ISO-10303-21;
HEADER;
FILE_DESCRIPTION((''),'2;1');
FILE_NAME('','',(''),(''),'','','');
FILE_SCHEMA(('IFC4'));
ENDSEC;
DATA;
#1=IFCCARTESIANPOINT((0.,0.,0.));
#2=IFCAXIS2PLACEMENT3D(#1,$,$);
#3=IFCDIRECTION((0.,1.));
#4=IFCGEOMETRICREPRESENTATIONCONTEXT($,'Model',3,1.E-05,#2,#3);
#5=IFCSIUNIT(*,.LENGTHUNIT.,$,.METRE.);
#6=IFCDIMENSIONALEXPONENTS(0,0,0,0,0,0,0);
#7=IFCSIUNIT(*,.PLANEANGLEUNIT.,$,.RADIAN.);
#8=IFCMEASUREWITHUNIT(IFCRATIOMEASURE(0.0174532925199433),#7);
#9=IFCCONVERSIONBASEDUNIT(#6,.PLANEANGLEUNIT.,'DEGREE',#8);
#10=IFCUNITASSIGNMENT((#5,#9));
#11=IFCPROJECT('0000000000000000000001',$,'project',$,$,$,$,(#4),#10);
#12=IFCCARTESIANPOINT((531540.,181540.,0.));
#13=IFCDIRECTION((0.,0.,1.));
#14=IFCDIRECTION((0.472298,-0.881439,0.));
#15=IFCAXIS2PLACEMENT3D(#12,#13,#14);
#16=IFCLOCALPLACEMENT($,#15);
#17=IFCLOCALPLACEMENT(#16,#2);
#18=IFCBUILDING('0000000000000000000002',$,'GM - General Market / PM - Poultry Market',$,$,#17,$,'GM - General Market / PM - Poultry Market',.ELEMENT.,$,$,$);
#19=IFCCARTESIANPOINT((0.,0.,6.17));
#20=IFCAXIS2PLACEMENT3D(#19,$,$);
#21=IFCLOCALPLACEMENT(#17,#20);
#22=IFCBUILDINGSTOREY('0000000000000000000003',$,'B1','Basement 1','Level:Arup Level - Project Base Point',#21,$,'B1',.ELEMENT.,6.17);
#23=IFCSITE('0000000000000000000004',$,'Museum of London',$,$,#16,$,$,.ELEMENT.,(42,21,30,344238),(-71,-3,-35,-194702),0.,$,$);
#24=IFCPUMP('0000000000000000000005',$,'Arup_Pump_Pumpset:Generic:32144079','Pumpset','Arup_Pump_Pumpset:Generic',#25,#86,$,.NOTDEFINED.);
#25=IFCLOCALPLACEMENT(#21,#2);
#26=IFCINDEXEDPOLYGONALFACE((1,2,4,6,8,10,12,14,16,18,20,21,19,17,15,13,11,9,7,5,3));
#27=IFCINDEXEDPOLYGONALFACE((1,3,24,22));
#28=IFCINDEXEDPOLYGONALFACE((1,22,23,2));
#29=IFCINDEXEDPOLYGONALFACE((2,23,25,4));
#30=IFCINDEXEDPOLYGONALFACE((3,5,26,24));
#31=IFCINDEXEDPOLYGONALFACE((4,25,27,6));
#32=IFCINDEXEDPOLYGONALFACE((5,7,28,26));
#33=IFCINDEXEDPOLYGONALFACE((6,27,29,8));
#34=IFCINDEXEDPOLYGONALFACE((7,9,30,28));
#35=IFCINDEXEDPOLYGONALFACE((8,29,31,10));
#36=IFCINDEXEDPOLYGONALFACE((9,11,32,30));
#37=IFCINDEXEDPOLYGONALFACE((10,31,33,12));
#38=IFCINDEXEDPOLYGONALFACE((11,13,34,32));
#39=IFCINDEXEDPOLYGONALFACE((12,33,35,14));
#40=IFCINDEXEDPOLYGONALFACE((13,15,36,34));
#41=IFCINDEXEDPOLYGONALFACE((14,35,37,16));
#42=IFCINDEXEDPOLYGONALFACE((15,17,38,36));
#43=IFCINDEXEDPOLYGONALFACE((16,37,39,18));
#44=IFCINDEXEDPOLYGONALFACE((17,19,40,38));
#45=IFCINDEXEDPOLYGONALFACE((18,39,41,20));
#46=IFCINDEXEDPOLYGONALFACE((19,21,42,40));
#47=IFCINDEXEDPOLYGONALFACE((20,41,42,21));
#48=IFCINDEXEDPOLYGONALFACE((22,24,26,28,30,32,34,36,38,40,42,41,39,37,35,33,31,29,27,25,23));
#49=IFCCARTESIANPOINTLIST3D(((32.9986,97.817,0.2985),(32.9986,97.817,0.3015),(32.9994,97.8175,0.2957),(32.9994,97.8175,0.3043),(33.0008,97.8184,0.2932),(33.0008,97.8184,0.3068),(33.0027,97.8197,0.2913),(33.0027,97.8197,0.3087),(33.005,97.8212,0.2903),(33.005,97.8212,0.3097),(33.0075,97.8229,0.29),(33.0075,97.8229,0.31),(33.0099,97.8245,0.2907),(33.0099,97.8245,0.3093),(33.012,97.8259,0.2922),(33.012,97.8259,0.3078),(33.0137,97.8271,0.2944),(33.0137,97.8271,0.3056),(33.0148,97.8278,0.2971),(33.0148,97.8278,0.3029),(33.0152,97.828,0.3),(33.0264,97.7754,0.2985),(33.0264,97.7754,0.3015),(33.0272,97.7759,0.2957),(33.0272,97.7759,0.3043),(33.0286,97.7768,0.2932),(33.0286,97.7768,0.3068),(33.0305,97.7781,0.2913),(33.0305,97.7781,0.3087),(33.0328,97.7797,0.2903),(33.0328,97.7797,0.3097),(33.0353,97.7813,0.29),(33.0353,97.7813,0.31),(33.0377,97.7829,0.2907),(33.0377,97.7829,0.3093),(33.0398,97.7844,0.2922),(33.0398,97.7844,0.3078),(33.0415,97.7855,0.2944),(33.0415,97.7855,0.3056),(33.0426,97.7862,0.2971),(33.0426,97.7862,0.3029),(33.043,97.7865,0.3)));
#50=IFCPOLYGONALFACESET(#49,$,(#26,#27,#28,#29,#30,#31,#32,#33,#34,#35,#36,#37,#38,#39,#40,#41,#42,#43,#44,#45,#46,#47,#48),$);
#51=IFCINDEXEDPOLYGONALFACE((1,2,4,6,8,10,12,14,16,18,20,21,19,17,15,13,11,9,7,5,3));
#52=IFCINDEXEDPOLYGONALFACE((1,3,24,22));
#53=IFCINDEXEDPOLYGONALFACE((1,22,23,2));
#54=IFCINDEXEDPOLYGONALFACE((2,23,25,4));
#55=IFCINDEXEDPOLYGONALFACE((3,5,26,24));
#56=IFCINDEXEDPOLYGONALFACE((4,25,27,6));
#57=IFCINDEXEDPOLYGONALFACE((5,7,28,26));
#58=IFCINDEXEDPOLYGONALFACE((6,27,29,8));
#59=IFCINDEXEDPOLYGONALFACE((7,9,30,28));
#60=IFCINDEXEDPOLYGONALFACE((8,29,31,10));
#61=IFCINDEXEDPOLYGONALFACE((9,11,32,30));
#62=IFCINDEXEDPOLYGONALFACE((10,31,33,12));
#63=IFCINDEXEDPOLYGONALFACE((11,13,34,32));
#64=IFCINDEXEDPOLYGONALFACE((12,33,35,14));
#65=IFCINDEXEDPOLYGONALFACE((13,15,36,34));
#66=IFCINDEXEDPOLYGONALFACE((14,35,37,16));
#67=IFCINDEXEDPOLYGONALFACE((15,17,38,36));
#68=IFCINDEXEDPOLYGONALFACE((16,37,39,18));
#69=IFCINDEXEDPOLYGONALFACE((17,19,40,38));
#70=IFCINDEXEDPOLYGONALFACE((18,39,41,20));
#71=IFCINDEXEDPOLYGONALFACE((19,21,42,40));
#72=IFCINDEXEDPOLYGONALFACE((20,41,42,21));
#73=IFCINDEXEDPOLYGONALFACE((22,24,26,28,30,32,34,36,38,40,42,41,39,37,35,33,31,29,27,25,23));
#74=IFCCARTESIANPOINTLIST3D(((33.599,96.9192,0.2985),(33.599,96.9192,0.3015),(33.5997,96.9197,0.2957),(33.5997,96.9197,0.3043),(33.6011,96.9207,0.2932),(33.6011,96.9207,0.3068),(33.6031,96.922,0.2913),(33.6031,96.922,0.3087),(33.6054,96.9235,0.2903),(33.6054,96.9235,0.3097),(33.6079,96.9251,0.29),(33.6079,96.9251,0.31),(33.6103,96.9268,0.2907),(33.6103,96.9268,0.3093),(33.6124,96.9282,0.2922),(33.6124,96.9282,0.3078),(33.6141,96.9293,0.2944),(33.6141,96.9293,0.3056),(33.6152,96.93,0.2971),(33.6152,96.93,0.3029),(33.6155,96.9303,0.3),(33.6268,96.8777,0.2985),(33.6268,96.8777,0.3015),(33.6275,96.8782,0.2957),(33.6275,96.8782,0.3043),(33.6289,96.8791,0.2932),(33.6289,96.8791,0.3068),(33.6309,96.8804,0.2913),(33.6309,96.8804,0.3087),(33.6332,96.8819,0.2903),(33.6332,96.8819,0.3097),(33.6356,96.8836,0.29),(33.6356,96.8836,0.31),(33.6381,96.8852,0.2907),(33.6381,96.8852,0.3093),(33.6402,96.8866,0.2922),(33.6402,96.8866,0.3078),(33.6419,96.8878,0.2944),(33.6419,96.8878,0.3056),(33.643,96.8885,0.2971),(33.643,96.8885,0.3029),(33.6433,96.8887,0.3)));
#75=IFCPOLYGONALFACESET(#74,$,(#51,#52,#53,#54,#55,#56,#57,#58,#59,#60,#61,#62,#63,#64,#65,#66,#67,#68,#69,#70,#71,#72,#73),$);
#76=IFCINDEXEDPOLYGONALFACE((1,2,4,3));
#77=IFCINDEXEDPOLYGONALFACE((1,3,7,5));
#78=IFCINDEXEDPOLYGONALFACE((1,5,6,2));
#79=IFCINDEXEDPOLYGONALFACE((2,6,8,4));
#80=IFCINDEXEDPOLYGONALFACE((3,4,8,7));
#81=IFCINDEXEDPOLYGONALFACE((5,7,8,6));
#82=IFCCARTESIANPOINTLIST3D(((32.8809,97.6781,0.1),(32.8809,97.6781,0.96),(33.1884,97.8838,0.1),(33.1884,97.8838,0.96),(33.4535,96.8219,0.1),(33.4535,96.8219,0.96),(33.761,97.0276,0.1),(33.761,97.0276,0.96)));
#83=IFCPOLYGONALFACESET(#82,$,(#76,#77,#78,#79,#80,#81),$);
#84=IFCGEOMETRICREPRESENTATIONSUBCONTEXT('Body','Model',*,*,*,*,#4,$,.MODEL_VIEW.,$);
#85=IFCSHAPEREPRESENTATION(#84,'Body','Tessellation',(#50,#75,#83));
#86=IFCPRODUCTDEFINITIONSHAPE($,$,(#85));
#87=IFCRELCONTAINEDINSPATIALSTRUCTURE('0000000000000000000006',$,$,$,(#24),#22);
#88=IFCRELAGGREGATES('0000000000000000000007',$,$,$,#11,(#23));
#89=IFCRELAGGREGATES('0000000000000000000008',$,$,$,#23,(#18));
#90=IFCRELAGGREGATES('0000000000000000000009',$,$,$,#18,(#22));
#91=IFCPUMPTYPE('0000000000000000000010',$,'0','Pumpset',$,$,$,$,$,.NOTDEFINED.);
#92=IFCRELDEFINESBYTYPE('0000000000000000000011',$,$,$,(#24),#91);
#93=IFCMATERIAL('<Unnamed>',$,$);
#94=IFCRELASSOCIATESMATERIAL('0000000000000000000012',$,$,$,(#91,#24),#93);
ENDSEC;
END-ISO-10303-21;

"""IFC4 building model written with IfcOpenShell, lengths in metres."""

from ifc_helpers import new_model, entity, si_unit, converted_unit, direction, frame, frame_2d, origin, origin_2d_with_axis, place, context, subcontext, project, spatial, rectangle, circle, extrude, source, transform, mapped, material, type_object, type_shapes, element, save


model = new_model("IFC4")

# Units and contexts
model_context = context("Model", 3, precision=1e-05, world=origin(), true_north=direction((0.0, 1.0)))
body_context = subcontext(model_context, "Body", "Model", "MODEL_VIEW")
ifc_project = project(units=[si_unit("LENGTHUNIT", "METRE"), converted_unit("PLANEANGLEUNIT", "DEGREE", entity("IfcRatioMeasure", 0.0174532925199433), si_unit("PLANEANGLEUNIT", "RADIAN"), dimensions=[0, 0, 0, 0, 0, 0, 0])], contexts=[model_context])

# Site, building, storey
site_placement = place(None, frame((531540.0, 181540.0, 0.0), z_axis=(0.0, 0.0, 1.0), x_axis=(0.472298, -0.881439, 0.0)))
site = spatial("IfcSite", under=ifc_project, at=site_placement, Name="Museum of London", CompositionType="ELEMENT", RefLatitude=(42, 21, 30, 344238), RefLongitude=(-71, -3, -35, -194702), RefElevation=0.0)
building_placement = place(site_placement, origin())
building = spatial("IfcBuilding", under=site, at=building_placement, Name="GM - General Market / PM - Poultry Market", LongName="GM - General Market / PM - Poultry Market", CompositionType="ELEMENT")
storey_placement = place(building_placement, frame((0.0, 0.0, 6.17)))
storey = spatial("IfcBuildingStorey", under=building, at=storey_placement, Name="B1", Description="Basement 1", ObjectType="Level:Arup Level - Project Base Point", LongName="B1", CompositionType="ELEMENT", Elevation=6.17)

# Shared definitions
ifc_material_1 = material(Name="<Unnamed>")

# Pump
pump_type = type_object("IfcPumpType", Name="0", Description="Pumpset", PredefinedType="NOTDEFINED", material=ifc_material_1)
shared_shape_1 = source(origin(), body_context, "Body", "SweptSolid", [
    extrude(circle(Radius=0.01, at=frame_2d((0.0, 0.0), x_axis=(1.0, 0.0))), frame((-0.015, 0.515, 0.2), z_axis=(0.0, 1.0, 0.0), x_axis=(1.0, 0.0, 0.0)), (0.0, 0.0, 1.0), 0.05),
    extrude(circle(Radius=0.01, at=frame_2d((0.0, 0.0), x_axis=(1.0, 0.0))), frame((-0.015, -0.565, 0.2), z_axis=(0.0, 1.0, 0.0), x_axis=(1.0, 0.0, 0.0)), (0.0, 0.0, 1.0), 0.05),
    extrude(rectangle(XDim=1.03, YDim=0.37, at=origin_2d_with_axis()), frame((-0.015, 0.0, 0.0), z_axis=(0.0, 0.0, 1.0), x_axis=(0.0, 1.0, 0.0)), (0.0, 0.0, 1.0), 0.86),
])
type_shapes(pump_type, [shared_shape_1])
pump_placement = place(storey_placement, frame((33.3334, 97.3612, 0.1), z_axis=(0.0, 0.0, 1.0), x_axis=(0.831246, 0.555905, 0.0)))
element("IfcPump", 1, at=pump_placement, inside=storey, type_object=pump_type, material=ifc_material_1, Name="Arup_Pump_Pumpset:Generic:32144079", Description="Pumpset", ObjectType="Arup_Pump_Pumpset:Generic", PredefinedType="NOTDEFINED", context=body_context, shape_type="MappedRepresentation", body=[
    mapped(shared_shape_1, transform((0.0, 0.0, 0.0), scale=1.0)),
])

save(model, "model.ifc")
